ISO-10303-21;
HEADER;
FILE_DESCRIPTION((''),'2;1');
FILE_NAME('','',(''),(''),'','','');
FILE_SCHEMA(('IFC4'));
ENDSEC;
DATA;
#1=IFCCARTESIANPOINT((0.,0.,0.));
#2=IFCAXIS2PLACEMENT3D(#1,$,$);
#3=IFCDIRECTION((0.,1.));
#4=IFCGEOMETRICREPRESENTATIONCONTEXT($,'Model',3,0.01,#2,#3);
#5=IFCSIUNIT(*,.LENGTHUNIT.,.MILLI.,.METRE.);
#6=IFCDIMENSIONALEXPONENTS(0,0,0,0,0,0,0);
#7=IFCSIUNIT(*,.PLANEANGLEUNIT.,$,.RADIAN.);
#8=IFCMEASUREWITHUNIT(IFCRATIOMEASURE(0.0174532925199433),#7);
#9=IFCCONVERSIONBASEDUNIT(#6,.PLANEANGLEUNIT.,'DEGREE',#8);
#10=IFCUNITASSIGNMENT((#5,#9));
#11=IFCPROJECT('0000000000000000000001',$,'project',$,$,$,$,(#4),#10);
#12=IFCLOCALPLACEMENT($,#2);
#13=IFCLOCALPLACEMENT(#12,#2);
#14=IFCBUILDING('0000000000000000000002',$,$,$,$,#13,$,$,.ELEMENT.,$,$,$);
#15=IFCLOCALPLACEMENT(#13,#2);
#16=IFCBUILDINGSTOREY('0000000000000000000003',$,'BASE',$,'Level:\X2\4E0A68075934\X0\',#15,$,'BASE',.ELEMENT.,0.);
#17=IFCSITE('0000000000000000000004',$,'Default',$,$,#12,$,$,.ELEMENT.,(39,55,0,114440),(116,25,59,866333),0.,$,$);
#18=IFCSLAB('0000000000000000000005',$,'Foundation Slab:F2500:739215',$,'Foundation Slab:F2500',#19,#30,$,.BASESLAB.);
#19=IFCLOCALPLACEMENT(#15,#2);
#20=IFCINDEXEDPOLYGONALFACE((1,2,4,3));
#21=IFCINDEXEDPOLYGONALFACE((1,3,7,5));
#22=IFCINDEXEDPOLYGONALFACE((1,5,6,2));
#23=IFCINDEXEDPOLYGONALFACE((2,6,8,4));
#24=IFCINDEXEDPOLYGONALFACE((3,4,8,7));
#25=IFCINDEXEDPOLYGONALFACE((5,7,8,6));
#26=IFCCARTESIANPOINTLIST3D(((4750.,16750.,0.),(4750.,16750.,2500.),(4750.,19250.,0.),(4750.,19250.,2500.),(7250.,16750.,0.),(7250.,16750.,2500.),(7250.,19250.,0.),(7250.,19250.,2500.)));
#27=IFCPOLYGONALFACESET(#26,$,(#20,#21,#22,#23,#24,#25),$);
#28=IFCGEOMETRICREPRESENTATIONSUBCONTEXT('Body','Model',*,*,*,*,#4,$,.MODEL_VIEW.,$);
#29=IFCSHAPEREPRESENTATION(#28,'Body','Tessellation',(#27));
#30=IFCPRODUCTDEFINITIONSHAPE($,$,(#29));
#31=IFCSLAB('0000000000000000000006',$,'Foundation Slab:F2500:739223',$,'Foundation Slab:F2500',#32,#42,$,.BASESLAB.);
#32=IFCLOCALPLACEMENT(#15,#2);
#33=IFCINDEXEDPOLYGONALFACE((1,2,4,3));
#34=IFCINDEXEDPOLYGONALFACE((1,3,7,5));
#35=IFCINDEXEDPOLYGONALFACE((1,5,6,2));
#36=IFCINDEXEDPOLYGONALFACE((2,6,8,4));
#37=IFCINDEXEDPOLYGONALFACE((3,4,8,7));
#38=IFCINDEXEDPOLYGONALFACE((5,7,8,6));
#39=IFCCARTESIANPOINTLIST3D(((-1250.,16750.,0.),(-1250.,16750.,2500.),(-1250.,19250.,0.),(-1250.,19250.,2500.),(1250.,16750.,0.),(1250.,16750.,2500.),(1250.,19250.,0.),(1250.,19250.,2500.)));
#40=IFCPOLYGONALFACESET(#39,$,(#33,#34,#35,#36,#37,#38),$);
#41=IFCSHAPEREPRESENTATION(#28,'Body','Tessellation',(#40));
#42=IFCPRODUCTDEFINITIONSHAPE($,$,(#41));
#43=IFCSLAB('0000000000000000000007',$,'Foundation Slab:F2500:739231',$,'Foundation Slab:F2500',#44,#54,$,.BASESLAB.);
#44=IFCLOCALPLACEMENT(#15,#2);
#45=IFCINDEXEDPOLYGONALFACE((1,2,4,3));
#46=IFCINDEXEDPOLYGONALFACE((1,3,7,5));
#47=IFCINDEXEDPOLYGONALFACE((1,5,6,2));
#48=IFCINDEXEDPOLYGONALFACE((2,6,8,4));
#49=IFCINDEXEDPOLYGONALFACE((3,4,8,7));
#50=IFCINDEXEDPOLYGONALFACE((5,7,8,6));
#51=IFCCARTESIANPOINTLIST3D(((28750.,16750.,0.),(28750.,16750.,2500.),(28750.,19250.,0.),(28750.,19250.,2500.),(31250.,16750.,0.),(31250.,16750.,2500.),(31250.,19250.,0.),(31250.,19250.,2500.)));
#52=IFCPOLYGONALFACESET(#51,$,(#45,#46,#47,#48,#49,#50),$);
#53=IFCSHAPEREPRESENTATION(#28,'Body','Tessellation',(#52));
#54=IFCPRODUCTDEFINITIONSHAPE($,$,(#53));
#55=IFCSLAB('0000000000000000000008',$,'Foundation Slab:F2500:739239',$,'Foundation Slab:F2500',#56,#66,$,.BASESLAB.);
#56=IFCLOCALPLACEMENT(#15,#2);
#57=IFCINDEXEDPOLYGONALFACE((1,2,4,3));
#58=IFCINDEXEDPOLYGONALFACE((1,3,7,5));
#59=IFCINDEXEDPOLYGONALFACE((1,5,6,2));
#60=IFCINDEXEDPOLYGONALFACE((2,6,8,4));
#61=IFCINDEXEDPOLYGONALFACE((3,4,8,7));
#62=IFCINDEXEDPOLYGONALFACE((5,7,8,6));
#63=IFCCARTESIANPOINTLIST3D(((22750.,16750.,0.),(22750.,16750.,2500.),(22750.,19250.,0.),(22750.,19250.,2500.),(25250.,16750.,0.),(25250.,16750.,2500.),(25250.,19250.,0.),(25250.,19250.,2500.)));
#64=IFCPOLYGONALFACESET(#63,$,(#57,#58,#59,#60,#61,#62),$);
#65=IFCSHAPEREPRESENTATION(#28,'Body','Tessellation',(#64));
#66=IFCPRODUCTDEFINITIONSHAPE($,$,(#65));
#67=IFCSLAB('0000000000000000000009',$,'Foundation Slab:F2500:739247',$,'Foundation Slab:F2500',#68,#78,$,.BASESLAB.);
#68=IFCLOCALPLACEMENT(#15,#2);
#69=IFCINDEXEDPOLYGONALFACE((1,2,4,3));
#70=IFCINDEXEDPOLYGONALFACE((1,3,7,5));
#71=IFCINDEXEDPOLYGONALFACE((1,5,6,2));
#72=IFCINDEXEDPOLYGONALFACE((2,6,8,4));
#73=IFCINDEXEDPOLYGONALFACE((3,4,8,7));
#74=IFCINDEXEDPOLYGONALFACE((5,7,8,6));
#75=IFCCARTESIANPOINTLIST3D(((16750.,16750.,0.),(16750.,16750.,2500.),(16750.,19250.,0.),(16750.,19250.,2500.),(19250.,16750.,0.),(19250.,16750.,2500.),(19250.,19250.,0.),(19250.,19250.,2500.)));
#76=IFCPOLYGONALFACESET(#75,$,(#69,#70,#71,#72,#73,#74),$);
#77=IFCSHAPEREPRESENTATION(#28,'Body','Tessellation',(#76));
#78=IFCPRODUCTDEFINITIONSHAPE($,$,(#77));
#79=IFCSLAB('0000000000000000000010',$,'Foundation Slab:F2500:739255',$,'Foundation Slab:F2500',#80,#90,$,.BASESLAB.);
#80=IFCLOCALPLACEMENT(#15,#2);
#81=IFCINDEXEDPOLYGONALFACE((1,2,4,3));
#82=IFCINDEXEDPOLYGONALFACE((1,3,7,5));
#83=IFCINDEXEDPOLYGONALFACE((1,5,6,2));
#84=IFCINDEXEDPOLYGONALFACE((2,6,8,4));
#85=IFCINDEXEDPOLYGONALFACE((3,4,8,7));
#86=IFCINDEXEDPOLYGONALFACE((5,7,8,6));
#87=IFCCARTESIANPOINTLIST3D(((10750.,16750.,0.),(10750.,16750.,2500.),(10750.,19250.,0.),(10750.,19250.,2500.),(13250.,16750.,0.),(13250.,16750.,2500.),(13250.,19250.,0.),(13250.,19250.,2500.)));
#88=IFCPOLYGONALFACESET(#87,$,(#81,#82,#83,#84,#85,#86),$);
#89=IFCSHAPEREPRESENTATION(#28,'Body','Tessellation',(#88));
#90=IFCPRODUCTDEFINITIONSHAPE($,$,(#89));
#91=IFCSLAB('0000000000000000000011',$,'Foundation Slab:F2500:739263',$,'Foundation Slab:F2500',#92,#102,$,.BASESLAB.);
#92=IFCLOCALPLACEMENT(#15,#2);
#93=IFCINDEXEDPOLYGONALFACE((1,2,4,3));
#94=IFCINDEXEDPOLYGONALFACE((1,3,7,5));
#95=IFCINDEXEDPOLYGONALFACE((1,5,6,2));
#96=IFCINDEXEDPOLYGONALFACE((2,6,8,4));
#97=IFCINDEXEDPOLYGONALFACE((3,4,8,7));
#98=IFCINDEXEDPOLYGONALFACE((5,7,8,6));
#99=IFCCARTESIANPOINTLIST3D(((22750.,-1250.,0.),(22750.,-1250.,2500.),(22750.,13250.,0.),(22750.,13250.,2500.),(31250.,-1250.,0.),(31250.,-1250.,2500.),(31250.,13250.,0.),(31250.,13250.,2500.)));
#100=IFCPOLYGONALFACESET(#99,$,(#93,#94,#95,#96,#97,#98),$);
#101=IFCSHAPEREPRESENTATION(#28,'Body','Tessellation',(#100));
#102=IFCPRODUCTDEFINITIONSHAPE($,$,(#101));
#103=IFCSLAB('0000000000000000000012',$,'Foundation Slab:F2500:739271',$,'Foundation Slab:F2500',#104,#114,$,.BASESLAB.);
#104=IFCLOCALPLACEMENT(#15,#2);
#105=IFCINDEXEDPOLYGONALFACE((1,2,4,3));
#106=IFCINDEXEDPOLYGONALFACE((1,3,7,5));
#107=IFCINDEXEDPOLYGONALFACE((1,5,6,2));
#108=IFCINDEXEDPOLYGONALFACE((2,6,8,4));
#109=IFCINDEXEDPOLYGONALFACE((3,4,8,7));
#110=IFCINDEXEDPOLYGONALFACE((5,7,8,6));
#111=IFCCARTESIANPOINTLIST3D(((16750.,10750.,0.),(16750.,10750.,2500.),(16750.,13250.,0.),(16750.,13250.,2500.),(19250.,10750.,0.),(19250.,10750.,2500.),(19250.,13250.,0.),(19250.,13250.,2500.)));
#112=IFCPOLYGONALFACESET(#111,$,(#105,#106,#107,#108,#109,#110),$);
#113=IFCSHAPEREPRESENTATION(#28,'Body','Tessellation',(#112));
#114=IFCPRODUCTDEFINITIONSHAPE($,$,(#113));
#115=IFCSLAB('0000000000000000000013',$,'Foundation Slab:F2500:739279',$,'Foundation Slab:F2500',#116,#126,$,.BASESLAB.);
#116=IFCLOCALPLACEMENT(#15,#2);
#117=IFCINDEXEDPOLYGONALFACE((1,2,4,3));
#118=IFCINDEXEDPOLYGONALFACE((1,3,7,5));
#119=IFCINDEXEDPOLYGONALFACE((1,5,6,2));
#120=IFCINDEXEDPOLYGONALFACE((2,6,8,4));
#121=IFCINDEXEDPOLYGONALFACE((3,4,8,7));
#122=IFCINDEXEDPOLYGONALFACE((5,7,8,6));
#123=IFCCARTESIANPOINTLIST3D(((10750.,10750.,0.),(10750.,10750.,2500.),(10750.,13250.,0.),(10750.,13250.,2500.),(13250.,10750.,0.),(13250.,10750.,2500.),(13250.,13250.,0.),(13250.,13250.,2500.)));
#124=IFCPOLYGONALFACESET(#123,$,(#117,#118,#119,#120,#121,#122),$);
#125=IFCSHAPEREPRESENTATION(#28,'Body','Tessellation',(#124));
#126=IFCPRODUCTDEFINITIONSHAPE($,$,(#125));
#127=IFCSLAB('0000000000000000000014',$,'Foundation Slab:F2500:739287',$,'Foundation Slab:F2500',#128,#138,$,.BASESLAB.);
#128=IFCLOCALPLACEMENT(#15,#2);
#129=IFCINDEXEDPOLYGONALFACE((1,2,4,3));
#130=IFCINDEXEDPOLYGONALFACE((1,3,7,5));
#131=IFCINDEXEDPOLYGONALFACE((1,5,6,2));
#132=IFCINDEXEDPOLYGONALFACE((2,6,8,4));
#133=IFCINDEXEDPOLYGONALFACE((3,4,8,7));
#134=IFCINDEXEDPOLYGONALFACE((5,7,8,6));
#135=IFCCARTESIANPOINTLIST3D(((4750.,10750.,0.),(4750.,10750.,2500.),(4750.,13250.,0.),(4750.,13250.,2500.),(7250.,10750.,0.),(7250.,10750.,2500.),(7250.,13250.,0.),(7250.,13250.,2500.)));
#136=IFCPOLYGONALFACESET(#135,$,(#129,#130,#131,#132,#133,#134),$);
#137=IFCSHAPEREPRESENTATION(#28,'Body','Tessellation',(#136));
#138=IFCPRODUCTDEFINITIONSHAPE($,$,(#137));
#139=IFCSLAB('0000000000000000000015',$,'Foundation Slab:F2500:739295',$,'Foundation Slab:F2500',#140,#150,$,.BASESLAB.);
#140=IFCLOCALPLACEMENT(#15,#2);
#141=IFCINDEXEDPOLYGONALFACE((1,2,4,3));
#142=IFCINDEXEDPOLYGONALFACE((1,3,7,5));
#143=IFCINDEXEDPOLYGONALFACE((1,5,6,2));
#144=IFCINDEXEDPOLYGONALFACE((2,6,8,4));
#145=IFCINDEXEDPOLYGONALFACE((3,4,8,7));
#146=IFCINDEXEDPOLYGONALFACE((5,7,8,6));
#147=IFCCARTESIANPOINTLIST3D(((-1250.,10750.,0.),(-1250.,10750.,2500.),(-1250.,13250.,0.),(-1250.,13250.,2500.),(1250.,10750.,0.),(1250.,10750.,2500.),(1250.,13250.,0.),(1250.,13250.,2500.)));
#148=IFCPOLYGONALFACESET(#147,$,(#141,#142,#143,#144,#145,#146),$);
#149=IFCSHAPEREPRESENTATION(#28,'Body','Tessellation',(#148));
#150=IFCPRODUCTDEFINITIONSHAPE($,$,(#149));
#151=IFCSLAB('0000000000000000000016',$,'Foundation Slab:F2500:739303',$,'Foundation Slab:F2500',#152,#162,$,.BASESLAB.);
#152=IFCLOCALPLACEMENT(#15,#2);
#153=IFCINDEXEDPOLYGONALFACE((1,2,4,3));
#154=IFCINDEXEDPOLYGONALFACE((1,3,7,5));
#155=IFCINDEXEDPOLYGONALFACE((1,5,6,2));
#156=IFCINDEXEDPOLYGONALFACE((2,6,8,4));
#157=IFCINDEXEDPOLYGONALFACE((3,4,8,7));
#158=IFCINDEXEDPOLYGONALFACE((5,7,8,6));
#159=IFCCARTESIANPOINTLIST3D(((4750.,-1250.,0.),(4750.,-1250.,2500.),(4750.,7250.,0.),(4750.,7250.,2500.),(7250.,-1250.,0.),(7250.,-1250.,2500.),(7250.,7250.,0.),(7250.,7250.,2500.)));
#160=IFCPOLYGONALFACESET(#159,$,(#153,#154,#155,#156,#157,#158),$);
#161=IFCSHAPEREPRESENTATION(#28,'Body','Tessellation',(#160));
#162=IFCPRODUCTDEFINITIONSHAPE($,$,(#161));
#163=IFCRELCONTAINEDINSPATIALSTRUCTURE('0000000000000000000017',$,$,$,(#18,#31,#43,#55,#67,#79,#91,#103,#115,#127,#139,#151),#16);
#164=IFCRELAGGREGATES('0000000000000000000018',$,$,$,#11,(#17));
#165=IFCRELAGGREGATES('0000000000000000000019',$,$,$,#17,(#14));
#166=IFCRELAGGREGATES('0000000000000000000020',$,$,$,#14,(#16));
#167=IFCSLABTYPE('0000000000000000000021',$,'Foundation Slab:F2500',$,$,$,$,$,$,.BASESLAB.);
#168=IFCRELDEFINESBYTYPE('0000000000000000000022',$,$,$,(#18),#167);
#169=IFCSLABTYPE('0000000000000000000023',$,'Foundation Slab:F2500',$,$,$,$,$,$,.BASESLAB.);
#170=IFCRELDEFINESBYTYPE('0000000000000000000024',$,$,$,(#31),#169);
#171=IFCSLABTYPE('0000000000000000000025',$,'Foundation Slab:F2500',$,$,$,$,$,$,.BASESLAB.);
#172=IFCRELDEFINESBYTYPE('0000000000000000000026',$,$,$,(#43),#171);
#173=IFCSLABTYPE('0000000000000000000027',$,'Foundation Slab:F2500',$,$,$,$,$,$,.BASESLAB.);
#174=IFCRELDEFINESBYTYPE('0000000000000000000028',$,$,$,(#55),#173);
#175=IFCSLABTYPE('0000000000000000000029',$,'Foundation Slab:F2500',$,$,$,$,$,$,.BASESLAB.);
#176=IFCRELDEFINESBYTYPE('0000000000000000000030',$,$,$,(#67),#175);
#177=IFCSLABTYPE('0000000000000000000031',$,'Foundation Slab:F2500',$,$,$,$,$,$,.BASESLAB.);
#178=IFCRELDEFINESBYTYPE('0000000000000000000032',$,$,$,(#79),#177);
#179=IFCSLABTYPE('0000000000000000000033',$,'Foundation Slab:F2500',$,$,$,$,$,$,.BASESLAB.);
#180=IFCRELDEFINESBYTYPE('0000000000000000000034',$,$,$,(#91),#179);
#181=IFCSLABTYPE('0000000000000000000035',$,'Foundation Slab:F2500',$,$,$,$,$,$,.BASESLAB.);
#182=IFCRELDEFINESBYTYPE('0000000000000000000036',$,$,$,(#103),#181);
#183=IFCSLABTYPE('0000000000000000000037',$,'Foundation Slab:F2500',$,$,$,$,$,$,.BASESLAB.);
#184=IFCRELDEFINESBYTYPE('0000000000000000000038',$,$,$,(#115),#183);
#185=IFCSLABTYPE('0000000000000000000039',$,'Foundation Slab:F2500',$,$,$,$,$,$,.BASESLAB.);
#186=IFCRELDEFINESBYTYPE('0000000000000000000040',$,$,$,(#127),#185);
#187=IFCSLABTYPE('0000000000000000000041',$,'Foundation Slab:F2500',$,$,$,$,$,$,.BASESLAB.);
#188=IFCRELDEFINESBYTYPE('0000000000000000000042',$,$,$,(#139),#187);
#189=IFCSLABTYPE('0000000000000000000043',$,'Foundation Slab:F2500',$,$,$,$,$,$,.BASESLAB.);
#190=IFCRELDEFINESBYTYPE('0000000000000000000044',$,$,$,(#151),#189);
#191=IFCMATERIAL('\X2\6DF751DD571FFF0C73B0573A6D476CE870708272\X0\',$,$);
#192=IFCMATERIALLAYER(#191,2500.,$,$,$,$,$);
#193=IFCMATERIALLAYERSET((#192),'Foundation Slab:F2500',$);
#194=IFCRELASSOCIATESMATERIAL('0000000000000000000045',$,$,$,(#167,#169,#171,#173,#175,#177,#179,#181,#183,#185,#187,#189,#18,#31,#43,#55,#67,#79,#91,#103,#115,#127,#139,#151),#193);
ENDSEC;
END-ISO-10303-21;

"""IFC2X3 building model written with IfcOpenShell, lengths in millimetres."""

from ifc_helpers import new_model, entity, si_unit, converted_unit, direction, frame, origin, origin_2d_with_axis, place, context, subcontext, project, spatial, rectangle, extrude, material, layer, layer_set, layer_usage, type_object, element, save


model = new_model("IFC2X3")

# Units and contexts
model_context = context("Model", 3, precision=0.01, world=origin(), true_north=direction((0.0, 1.0)))
body_context = subcontext(model_context, "Body", "Model", "MODEL_VIEW")
ifc_project = project(units=[si_unit("LENGTHUNIT", "METRE", prefix="MILLI"), converted_unit("PLANEANGLEUNIT", "DEGREE", entity("IfcRatioMeasure", 0.0174532925199433), si_unit("PLANEANGLEUNIT", "RADIAN"), dimensions=[0, 0, 0, 0, 0, 0, 0])], contexts=[model_context])

# Site, building, storey
site_placement = place(None, origin())
site = spatial("IfcSite", under=ifc_project, at=site_placement, Name="Default", CompositionType="ELEMENT", RefLatitude=(39, 55, 0, 114440), RefLongitude=(116, 25, 59, 866333), RefElevation=0.0)
building_placement = place(site_placement, origin())
building = spatial("IfcBuilding", under=site, at=building_placement, CompositionType="ELEMENT")
storey_placement = place(building_placement, origin())
storey = spatial("IfcBuildingStorey", under=building, at=storey_placement, Name="BASE", ObjectType="Level:上标头", LongName="BASE", CompositionType="ELEMENT", Elevation=0.0)

# Slabs
ifc_material = material(Name="混凝土，现场浇注灰色")
ifc_layer = layer(ifc_material, 2500.0)
ifc_layer_set = layer_set([ifc_layer], Name="Foundation Slab:F2500")
ifc_layer_usage_1 = layer_usage(ifc_layer_set, "AXIS3", "POSITIVE", 0.0)
slab_type_1 = type_object("IfcSlabType", Name="Foundation Slab:F2500", PredefinedType="BASESLAB", material=ifc_layer_set)
slab_1_placement = place(storey_placement, origin())
element("IfcSlab", 1, at=slab_1_placement, inside=storey, type_object=slab_type_1, material=ifc_layer_usage_1, Name="Foundation Slab:F2500:739215", ObjectType="Foundation Slab:F2500", PredefinedType="BASESLAB", context=body_context, shape_type="SweptSolid", body=[
    extrude(rectangle(XDim=2500.0, YDim=2500.0, at=origin_2d_with_axis()), frame((6000.0, 18000.0, 2500.0), z_axis=(0.0, 0.0, -1.0), x_axis=(0.0, 1.0, 0.0)), (0.0, 0.0, 1.0), 2500.0),
])
ifc_layer_usage_2 = layer_usage(ifc_layer_set, "AXIS3", "POSITIVE", 0.0)
slab_type_2 = type_object("IfcSlabType", Name="Foundation Slab:F2500", PredefinedType="BASESLAB", material=ifc_layer_set)
slab_2_placement = place(storey_placement, origin())
element("IfcSlab", 2, at=slab_2_placement, inside=storey, type_object=slab_type_2, material=ifc_layer_usage_2, Name="Foundation Slab:F2500:739223", ObjectType="Foundation Slab:F2500", PredefinedType="BASESLAB", context=body_context, shape_type="SweptSolid", body=[
    extrude(rectangle(XDim=2500.0, YDim=2500.0, at=origin_2d_with_axis()), frame((0.0, 18000.0, 2500.0), z_axis=(0.0, 0.0, -1.0), x_axis=(0.0, 1.0, 0.0)), (0.0, 0.0, 1.0), 2500.0),
])
ifc_layer_usage_3 = layer_usage(ifc_layer_set, "AXIS3", "POSITIVE", 0.0)
slab_type_3 = type_object("IfcSlabType", Name="Foundation Slab:F2500", PredefinedType="BASESLAB", material=ifc_layer_set)
slab_3_placement = place(storey_placement, origin())
element("IfcSlab", 3, at=slab_3_placement, inside=storey, type_object=slab_type_3, material=ifc_layer_usage_3, Name="Foundation Slab:F2500:739231", ObjectType="Foundation Slab:F2500", PredefinedType="BASESLAB", context=body_context, shape_type="SweptSolid", body=[
    extrude(rectangle(XDim=2500.0, YDim=2500.0, at=origin_2d_with_axis()), frame((30000.0, 18000.0, 2500.0), z_axis=(0.0, 0.0, -1.0), x_axis=(0.0, 1.0, 0.0)), (0.0, 0.0, 1.0), 2500.0),
])
ifc_layer_usage_4 = layer_usage(ifc_layer_set, "AXIS3", "POSITIVE", 0.0)
slab_type_4 = type_object("IfcSlabType", Name="Foundation Slab:F2500", PredefinedType="BASESLAB", material=ifc_layer_set)
slab_4_placement = place(storey_placement, origin())
element("IfcSlab", 4, at=slab_4_placement, inside=storey, type_object=slab_type_4, material=ifc_layer_usage_4, Name="Foundation Slab:F2500:739239", ObjectType="Foundation Slab:F2500", PredefinedType="BASESLAB", context=body_context, shape_type="SweptSolid", body=[
    extrude(rectangle(XDim=2500.0, YDim=2500.0, at=origin_2d_with_axis()), frame((24000.0, 18000.0, 2500.0), z_axis=(0.0, 0.0, -1.0), x_axis=(0.0, 1.0, 0.0)), (0.0, 0.0, 1.0), 2500.0),
])
ifc_layer_usage_5 = layer_usage(ifc_layer_set, "AXIS3", "POSITIVE", 0.0)
slab_type_5 = type_object("IfcSlabType", Name="Foundation Slab:F2500", PredefinedType="BASESLAB", material=ifc_layer_set)
slab_5_placement = place(storey_placement, origin())
element("IfcSlab", 5, at=slab_5_placement, inside=storey, type_object=slab_type_5, material=ifc_layer_usage_5, Name="Foundation Slab:F2500:739247", ObjectType="Foundation Slab:F2500", PredefinedType="BASESLAB", context=body_context, shape_type="SweptSolid", body=[
    extrude(rectangle(XDim=2500.0, YDim=2500.0, at=origin_2d_with_axis()), frame((18000.0, 18000.0, 2500.0), z_axis=(0.0, 0.0, -1.0), x_axis=(0.0, 1.0, 0.0)), (0.0, 0.0, 1.0), 2500.0),
])
ifc_layer_usage_6 = layer_usage(ifc_layer_set, "AXIS3", "POSITIVE", 0.0)
slab_type_6 = type_object("IfcSlabType", Name="Foundation Slab:F2500", PredefinedType="BASESLAB", material=ifc_layer_set)
slab_6_placement = place(storey_placement, origin())
element("IfcSlab", 6, at=slab_6_placement, inside=storey, type_object=slab_type_6, material=ifc_layer_usage_6, Name="Foundation Slab:F2500:739255", ObjectType="Foundation Slab:F2500", PredefinedType="BASESLAB", context=body_context, shape_type="SweptSolid", body=[
    extrude(rectangle(XDim=2500.0, YDim=2500.0, at=origin_2d_with_axis()), frame((12000.0, 18000.0, 2500.0), z_axis=(0.0, 0.0, -1.0), x_axis=(0.0, 1.0, 0.0)), (0.0, 0.0, 1.0), 2500.0),
])
ifc_layer_usage_7 = layer_usage(ifc_layer_set, "AXIS3", "POSITIVE", 0.0)
slab_type_7 = type_object("IfcSlabType", Name="Foundation Slab:F2500", PredefinedType="BASESLAB", material=ifc_layer_set)
slab_7_placement = place(storey_placement, origin())
element("IfcSlab", 7, at=slab_7_placement, inside=storey, type_object=slab_type_7, material=ifc_layer_usage_7, Name="Foundation Slab:F2500:739263", ObjectType="Foundation Slab:F2500", PredefinedType="BASESLAB", context=body_context, shape_type="SweptSolid", body=[
    extrude(rectangle(XDim=14500.0, YDim=8500.0, at=origin_2d_with_axis()), frame((27000.0, 6000.0, 2500.0), z_axis=(0.0, 0.0, -1.0), x_axis=(0.0, 1.0, 0.0)), (0.0, 0.0, 1.0), 2500.0),
])
ifc_layer_usage_8 = layer_usage(ifc_layer_set, "AXIS3", "POSITIVE", 0.0)
slab_type_8 = type_object("IfcSlabType", Name="Foundation Slab:F2500", PredefinedType="BASESLAB", material=ifc_layer_set)
slab_8_placement = place(storey_placement, origin())
element("IfcSlab", 8, at=slab_8_placement, inside=storey, type_object=slab_type_8, material=ifc_layer_usage_8, Name="Foundation Slab:F2500:739271", ObjectType="Foundation Slab:F2500", PredefinedType="BASESLAB", context=body_context, shape_type="SweptSolid", body=[
    extrude(rectangle(XDim=2500.0, YDim=2500.0, at=origin_2d_with_axis()), frame((18000.0, 12000.0, 2500.0), z_axis=(0.0, 0.0, -1.0), x_axis=(0.0, 1.0, 0.0)), (0.0, 0.0, 1.0), 2500.0),
])
ifc_layer_usage_9 = layer_usage(ifc_layer_set, "AXIS3", "POSITIVE", 0.0)
slab_type_9 = type_object("IfcSlabType", Name="Foundation Slab:F2500", PredefinedType="BASESLAB", material=ifc_layer_set)
slab_9_placement = place(storey_placement, origin())
element("IfcSlab", 9, at=slab_9_placement, inside=storey, type_object=slab_type_9, material=ifc_layer_usage_9, Name="Foundation Slab:F2500:739279", ObjectType="Foundation Slab:F2500", PredefinedType="BASESLAB", context=body_context, shape_type="SweptSolid", body=[
    extrude(rectangle(XDim=2500.0, YDim=2500.0, at=origin_2d_with_axis()), frame((12000.0, 12000.0, 2500.0), z_axis=(0.0, 0.0, -1.0), x_axis=(0.0, 1.0, 0.0)), (0.0, 0.0, 1.0), 2500.0),
])
ifc_layer_usage_10 = layer_usage(ifc_layer_set, "AXIS3", "POSITIVE", 0.0)
slab_type_10 = type_object("IfcSlabType", Name="Foundation Slab:F2500", PredefinedType="BASESLAB", material=ifc_layer_set)
slab_10_placement = place(storey_placement, origin())
element("IfcSlab", 10, at=slab_10_placement, inside=storey, type_object=slab_type_10, material=ifc_layer_usage_10, Name="Foundation Slab:F2500:739287", ObjectType="Foundation Slab:F2500", PredefinedType="BASESLAB", context=body_context, shape_type="SweptSolid", body=[
    extrude(rectangle(XDim=2500.0, YDim=2500.0, at=origin_2d_with_axis()), frame((6000.0, 12000.0, 2500.0), z_axis=(0.0, 0.0, -1.0), x_axis=(0.0, 1.0, 0.0)), (0.0, 0.0, 1.0), 2500.0),
])
ifc_layer_usage_11 = layer_usage(ifc_layer_set, "AXIS3", "POSITIVE", 0.0)
slab_type_11 = type_object("IfcSlabType", Name="Foundation Slab:F2500", PredefinedType="BASESLAB", material=ifc_layer_set)
slab_11_placement = place(storey_placement, origin())
element("IfcSlab", 11, at=slab_11_placement, inside=storey, type_object=slab_type_11, material=ifc_layer_usage_11, Name="Foundation Slab:F2500:739295", ObjectType="Foundation Slab:F2500", PredefinedType="BASESLAB", context=body_context, shape_type="SweptSolid", body=[
    extrude(rectangle(XDim=2500.0, YDim=2500.0, at=origin_2d_with_axis()), frame((0.0, 12000.0, 2500.0), z_axis=(0.0, 0.0, -1.0), x_axis=(0.0, 1.0, 0.0)), (0.0, 0.0, 1.0), 2500.0),
])
ifc_layer_usage_12 = layer_usage(ifc_layer_set, "AXIS3", "POSITIVE", 0.0)
slab_type_12 = type_object("IfcSlabType", Name="Foundation Slab:F2500", PredefinedType="BASESLAB", material=ifc_layer_set)
slab_12_placement = place(storey_placement, origin())
element("IfcSlab", 12, at=slab_12_placement, inside=storey, type_object=slab_type_12, material=ifc_layer_usage_12, Name="Foundation Slab:F2500:739303", ObjectType="Foundation Slab:F2500", PredefinedType="BASESLAB", context=body_context, shape_type="SweptSolid", body=[
    extrude(rectangle(XDim=8500.0, YDim=2500.0, at=origin_2d_with_axis()), frame((6000.0, 3000.0, 2500.0), z_axis=(0.0, 0.0, -1.0), x_axis=(0.0, 1.0, 0.0)), (0.0, 0.0, 1.0), 2500.0),
])

save(model, "model.ifc")
